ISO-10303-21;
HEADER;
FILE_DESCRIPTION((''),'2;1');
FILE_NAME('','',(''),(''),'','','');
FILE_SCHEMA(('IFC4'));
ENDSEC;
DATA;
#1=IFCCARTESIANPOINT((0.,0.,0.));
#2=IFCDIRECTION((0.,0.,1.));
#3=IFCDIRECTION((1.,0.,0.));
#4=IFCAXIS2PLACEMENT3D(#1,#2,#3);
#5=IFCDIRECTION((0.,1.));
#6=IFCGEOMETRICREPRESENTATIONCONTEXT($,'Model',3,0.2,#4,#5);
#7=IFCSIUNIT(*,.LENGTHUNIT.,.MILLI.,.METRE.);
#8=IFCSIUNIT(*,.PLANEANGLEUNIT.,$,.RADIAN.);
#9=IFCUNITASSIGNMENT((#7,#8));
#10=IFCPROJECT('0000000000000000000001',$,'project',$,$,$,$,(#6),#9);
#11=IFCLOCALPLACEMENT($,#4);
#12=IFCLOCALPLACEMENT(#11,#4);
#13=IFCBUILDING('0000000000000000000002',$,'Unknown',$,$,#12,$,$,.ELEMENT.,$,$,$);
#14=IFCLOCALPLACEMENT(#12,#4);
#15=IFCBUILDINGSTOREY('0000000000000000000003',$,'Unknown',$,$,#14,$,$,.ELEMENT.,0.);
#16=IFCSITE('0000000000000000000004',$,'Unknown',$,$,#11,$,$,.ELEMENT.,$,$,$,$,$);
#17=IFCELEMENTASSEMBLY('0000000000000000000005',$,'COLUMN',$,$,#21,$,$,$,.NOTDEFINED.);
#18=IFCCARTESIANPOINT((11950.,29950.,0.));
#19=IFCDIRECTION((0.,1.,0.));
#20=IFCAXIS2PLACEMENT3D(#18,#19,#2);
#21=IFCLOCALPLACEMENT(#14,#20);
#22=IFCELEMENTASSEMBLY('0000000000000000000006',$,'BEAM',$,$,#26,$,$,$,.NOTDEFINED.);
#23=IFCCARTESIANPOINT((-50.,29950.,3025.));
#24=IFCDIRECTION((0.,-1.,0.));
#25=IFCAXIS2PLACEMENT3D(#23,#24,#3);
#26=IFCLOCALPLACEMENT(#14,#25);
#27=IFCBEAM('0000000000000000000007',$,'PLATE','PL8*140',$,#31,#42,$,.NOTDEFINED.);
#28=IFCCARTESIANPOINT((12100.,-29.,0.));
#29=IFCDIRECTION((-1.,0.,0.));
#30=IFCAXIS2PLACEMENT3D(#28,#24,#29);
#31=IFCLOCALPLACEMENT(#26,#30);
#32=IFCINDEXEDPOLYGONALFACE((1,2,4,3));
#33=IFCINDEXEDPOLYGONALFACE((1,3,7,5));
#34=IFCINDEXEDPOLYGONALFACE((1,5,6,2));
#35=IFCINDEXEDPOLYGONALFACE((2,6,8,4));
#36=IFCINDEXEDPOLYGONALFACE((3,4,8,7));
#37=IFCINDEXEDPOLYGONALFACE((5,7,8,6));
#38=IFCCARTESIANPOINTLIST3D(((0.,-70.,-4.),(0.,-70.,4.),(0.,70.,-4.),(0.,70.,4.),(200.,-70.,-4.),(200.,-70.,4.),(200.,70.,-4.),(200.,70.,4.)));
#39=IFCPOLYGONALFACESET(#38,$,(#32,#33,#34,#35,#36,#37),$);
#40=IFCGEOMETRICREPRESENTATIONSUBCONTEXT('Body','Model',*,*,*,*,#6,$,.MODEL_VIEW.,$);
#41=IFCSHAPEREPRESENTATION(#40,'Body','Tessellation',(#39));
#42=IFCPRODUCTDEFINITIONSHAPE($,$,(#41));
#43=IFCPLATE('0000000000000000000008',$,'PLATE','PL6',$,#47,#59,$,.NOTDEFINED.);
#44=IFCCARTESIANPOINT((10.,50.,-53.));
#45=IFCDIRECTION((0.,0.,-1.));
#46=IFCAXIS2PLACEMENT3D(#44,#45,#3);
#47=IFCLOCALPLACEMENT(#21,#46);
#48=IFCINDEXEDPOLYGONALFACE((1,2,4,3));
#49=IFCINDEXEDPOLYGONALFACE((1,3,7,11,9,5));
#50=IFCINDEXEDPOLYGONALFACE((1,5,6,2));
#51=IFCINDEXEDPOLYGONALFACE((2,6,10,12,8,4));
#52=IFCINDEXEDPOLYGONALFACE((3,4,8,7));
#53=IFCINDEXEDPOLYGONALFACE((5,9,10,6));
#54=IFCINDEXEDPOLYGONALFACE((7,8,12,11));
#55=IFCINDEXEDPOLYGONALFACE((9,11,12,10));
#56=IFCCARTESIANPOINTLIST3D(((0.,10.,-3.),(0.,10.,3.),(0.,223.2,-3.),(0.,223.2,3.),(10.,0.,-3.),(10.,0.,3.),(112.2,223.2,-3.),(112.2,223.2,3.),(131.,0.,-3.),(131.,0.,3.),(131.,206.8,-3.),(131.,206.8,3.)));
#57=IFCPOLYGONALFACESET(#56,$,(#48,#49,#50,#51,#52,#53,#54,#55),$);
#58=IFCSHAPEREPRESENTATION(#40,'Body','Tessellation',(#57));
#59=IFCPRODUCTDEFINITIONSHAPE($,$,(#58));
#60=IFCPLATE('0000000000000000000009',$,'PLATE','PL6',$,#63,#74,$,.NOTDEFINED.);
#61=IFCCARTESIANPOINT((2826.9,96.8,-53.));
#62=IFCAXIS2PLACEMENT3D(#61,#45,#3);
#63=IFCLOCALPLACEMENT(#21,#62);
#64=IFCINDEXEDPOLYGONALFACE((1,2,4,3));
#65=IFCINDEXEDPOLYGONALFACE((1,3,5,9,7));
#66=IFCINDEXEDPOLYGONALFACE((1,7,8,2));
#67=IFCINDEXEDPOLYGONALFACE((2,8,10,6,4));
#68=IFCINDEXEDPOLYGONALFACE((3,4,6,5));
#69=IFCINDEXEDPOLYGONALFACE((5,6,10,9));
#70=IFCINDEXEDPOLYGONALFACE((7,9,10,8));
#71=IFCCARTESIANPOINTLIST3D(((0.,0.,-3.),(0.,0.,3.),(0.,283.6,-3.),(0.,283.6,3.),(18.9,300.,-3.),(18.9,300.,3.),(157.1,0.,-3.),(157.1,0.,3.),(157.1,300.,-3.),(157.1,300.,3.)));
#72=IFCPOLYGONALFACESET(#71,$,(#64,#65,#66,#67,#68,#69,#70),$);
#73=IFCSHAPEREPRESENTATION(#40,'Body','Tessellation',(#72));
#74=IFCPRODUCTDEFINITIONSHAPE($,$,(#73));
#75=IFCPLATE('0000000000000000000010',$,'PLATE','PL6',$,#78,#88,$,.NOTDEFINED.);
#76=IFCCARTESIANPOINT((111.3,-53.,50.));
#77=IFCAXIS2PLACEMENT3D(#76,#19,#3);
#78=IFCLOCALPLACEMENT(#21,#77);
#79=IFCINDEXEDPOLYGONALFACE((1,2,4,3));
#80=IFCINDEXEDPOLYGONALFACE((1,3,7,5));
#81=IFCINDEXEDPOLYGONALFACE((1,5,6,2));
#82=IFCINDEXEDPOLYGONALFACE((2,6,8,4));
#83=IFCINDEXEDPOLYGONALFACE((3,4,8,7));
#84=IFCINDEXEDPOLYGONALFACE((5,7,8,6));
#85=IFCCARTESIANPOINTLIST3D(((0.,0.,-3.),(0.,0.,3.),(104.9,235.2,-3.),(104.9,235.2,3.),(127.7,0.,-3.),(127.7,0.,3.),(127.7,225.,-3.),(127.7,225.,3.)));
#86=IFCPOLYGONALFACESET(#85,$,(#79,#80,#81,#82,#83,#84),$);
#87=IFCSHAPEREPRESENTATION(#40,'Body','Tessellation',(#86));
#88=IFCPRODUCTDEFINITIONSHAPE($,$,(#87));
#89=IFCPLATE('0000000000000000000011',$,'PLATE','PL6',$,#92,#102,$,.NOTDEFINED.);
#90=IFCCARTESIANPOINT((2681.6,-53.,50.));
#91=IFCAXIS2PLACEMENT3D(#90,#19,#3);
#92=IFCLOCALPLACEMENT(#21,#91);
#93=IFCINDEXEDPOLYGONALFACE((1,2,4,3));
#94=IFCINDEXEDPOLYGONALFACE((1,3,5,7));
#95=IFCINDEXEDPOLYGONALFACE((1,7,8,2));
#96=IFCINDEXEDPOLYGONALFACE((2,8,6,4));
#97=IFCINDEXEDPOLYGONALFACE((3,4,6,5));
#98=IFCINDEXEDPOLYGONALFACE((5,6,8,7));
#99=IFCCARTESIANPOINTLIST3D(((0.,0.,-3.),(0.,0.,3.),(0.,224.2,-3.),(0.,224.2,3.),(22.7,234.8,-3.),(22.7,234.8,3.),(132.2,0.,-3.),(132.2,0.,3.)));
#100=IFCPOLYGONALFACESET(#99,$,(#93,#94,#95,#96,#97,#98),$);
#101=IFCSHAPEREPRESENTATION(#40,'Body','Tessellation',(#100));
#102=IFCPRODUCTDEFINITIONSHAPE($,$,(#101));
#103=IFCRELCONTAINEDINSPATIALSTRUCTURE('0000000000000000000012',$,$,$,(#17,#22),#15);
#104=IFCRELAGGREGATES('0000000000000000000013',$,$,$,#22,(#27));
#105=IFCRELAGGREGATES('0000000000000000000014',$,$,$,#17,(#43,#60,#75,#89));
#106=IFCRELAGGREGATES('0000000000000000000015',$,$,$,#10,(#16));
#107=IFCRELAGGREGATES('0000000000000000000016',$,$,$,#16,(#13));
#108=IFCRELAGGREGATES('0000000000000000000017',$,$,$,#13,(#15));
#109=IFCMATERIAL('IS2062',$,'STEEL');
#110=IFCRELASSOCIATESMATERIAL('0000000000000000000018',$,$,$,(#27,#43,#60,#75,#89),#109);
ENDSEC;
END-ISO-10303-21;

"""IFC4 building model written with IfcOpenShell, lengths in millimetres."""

from ifc_helpers import new_model, si_unit, direction, frame, origin_with_axes, place, context, subcontext, project, spatial, line, indexed_curve, outline, extrude, material, element, aggregate, save


model = new_model("IFC4")

# Units and contexts
model_context = context("Model", 3, precision=0.2, world=origin_with_axes(), true_north=direction((0.0, 1.0)))
body_context = subcontext(model_context, "Body", "Model", "MODEL_VIEW")
ifc_project = project(units=[si_unit("LENGTHUNIT", "METRE", prefix="MILLI"), si_unit("PLANEANGLEUNIT", "RADIAN")], contexts=[model_context])

# Site, building, storey
site_placement = place(None, origin_with_axes())
site = spatial("IfcSite", under=ifc_project, at=site_placement, Name="Unknown", CompositionType="ELEMENT")
building_placement = place(site_placement, origin_with_axes())
building = spatial("IfcBuilding", under=site, at=building_placement, Name="Unknown", CompositionType="ELEMENT")
storey_placement = place(building_placement, origin_with_axes())
storey = spatial("IfcBuildingStorey", under=building, at=storey_placement, Name="Unknown", CompositionType="ELEMENT", Elevation=0.0)

# Shared definitions
ifc_material_1 = material(Name="IS2062", Category="STEEL")

# Element assemblies, beam
assembly_1_placement = place(storey_placement, frame((11950.0, 29950.0, 0.0), z_axis=(0.0, 1.0, 0.0), x_axis=(0.0, 0.0, 1.0)))
assembly_1 = element("IfcElementAssembly", 1, at=assembly_1_placement, inside=storey, Name="COLUMN", PredefinedType="NOTDEFINED")
assembly_2_placement = place(storey_placement, frame((-50.0, 29950.0, 3025.0), z_axis=(0.0, -1.0, 0.0), x_axis=(1.0, 0.0, 0.0)))
assembly_2 = element("IfcElementAssembly", 2, at=assembly_2_placement, inside=storey, Name="BEAM", PredefinedType="NOTDEFINED")
beam_1_placement = place(assembly_2_placement, frame((12100.0, -29.0, 0.0), z_axis=(0.0, -1.0, 0.0), x_axis=(-1.0, 0.0, 0.0)))
beam_1 = element("IfcBeam", 3, at=beam_1_placement, material=ifc_material_1, Name="PLATE", Description="PL8*140", PredefinedType="NOTDEFINED", context=body_context, shape_type="SolidModel", body=[
    extrude(outline(indexed_curve([(-4.0, -70.0), (4.0, -70.0), (4.0, 70.0), (-4.0, 70.0)], segments=[line(1, 2, 3, 4, 1)])), frame((0.0, 0.0, 0.0), z_axis=(-1.0, 0.0, 0.0), x_axis=(0.0, 0.0, 1.0)), (0.0, 0.0, -1.0), 200.0),
])
aggregate(assembly_2, [beam_1])

# Plates
plate_1_placement = place(assembly_1_placement, frame((10.0, 50.0, -53.0), z_axis=(0.0, 0.0, -1.0), x_axis=(1.0, 0.0, 0.0)))
plate_1 = element("IfcPlate", 4, at=plate_1_placement, material=ifc_material_1, Name="PLATE", Description="PL6", PredefinedType="NOTDEFINED", context=body_context, shape_type="SolidModel", body=[
    extrude(outline(indexed_curve([(0.0, 10.0), (10.0, 0.0), (131.0, 0.0), (131.0, 206.8), (112.2, 223.2), (0.0, 223.2)], segments=[line(1, 2, 3, 4, 5, 6, 1)])), frame((0.0, 0.0, 3.0), z_axis=(0.0, 0.0, 1.0), x_axis=(1.0, 0.0, 0.0)), (0.0, 0.0, -1.0), 6.0),
])
plate_2_placement = place(assembly_1_placement, frame((2826.9, 96.8, -53.0), z_axis=(0.0, 0.0, -1.0), x_axis=(1.0, 0.0, 0.0)))
plate_2 = element("IfcPlate", 5, at=plate_2_placement, material=ifc_material_1, Name="PLATE", Description="PL6", PredefinedType="NOTDEFINED", context=body_context, shape_type="SolidModel", body=[
    extrude(outline(indexed_curve([(0.0, 0.0), (157.1, 0.0), (157.1, 300.0), (18.9, 300.0), (0.0, 283.6)], segments=[line(1, 2, 3, 4, 5, 1)])), frame((0.0, 0.0, 3.0), z_axis=(0.0, 0.0, 1.0), x_axis=(1.0, 0.0, 0.0)), (0.0, 0.0, -1.0), 6.0),
])
plate_3_placement = place(assembly_1_placement, frame((111.3, -53.0, 50.0), z_axis=(0.0, 1.0, 0.0), x_axis=(1.0, 0.0, 0.0)))
plate_3 = element("IfcPlate", 6, at=plate_3_placement, material=ifc_material_1, Name="PLATE", Description="PL6", PredefinedType="NOTDEFINED", context=body_context, shape_type="SolidModel", body=[
    extrude(outline(indexed_curve([(0.0, 0.0), (127.7, 0.0), (127.7, 225.0), (104.9, 235.2)], segments=[line(1, 2, 3, 4, 1)])), frame((0.0, 0.0, 3.0), z_axis=(0.0, 0.0, 1.0), x_axis=(1.0, 0.0, 0.0)), (0.0, 0.0, -1.0), 6.0),
])
plate_4_placement = place(assembly_1_placement, frame((2681.6, -53.0, 50.0), z_axis=(0.0, 1.0, 0.0), x_axis=(1.0, 0.0, 0.0)))
plate_4 = element("IfcPlate", 7, at=plate_4_placement, material=ifc_material_1, Name="PLATE", Description="PL6", PredefinedType="NOTDEFINED", context=body_context, shape_type="SolidModel", body=[
    extrude(outline(indexed_curve([(0.0, 0.0), (132.2, 0.0), (22.7, 234.8), (0.0, 224.2)], segments=[line(1, 2, 3, 4, 1)])), frame((0.0, 0.0, 3.0), z_axis=(0.0, 0.0, 1.0), x_axis=(1.0, 0.0, 0.0)), (0.0, 0.0, -1.0), 6.0),
])

aggregate(assembly_1, [plate_1, plate_2, plate_3, plate_4])

save(model, "model.ifc")
